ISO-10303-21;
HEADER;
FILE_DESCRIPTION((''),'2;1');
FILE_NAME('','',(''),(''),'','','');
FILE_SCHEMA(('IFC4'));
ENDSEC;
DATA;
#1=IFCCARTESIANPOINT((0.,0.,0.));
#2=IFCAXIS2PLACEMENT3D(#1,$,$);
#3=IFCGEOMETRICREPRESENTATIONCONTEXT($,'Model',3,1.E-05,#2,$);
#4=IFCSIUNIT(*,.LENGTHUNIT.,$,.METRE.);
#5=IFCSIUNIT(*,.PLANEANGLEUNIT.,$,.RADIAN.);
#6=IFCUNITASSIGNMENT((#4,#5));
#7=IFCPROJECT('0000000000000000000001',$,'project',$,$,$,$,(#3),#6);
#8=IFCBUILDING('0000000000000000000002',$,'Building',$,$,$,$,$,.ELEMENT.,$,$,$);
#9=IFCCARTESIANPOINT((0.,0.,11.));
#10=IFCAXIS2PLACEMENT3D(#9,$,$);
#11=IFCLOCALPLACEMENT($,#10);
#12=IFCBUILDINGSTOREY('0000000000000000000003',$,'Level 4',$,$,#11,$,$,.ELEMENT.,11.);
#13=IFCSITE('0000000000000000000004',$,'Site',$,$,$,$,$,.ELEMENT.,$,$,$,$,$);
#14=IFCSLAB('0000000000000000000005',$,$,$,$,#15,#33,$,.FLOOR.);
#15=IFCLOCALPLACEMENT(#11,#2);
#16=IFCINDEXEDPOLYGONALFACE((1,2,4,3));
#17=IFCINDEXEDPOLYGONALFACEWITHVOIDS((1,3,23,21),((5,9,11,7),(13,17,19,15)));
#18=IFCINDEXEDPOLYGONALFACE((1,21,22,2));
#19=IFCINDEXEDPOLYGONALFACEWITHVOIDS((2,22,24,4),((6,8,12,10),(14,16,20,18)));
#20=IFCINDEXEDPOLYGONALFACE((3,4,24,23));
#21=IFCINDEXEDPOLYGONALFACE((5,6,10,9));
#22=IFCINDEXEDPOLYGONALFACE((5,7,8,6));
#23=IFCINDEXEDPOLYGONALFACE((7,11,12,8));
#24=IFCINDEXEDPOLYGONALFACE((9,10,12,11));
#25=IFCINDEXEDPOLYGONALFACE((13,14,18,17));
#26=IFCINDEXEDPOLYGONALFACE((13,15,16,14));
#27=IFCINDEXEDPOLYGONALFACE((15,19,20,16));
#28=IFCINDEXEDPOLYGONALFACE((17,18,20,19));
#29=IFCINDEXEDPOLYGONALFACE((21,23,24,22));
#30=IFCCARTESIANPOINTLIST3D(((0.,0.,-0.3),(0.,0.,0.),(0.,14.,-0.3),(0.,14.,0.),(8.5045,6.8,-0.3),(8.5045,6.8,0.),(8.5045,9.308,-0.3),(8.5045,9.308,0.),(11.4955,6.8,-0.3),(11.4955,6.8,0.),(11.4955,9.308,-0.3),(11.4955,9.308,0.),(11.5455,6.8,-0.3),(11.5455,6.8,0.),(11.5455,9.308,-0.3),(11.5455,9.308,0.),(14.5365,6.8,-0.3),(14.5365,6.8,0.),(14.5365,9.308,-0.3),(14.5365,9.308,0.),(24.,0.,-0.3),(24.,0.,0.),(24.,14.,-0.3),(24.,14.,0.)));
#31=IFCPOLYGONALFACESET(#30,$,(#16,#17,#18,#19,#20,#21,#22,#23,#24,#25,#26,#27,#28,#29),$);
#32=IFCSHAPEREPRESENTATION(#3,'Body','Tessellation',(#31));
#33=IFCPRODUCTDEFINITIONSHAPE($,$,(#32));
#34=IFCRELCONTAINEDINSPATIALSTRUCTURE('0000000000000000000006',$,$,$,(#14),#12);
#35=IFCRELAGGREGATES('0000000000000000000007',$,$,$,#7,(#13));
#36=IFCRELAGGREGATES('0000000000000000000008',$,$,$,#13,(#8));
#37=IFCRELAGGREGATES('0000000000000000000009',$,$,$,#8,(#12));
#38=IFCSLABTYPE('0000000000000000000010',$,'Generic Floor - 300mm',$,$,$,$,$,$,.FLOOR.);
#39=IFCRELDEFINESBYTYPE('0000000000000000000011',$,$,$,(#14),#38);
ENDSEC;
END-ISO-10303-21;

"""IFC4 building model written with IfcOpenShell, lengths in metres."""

from ifc_helpers import new_model, si_unit, frame, origin, place, context, project, spatial, polyline, outline, extrude, type_object, element, save


model = new_model("IFC4")

# Units and contexts
model_context = context("Model", 3, precision=1e-05, world=origin())
ifc_project = project(units=[si_unit("LENGTHUNIT", "METRE"), si_unit("PLANEANGLEUNIT", "RADIAN")], contexts=[model_context])

# Site, building, storey
site = spatial("IfcSite", under=ifc_project, Name="Site", CompositionType="ELEMENT")
building = spatial("IfcBuilding", under=site, Name="Building", CompositionType="ELEMENT")
storey_placement = place(None, frame((0.0, 0.0, 11.0)))
storey = spatial("IfcBuildingStorey", under=building, at=storey_placement, Name="Level 4", CompositionType="ELEMENT", Elevation=11.0)

# Slab, openings
slab_type = type_object("IfcSlabType", Name="Generic Floor - 300mm", PredefinedType="FLOOR")
slab_placement = place(None, frame((0.0, 0.0, 11.0)))
slab = element("IfcSlab", 1, at=slab_placement, inside=storey, type_object=slab_type, PredefinedType="FLOOR", context=model_context, shape_type="SweptSolid", body=[
    extrude(outline(polyline([(0.0, 0.0), (24.0, 0.0), (24.0, 14.0), (0.0, 14.0), (0.0, 0.0)])), origin(), (0.0, 0.0, -1.0), 0.3),
])
opening_1_placement = place(None, frame((0.0, 0.0, 11.001)))
element("IfcOpeningElement", 2, at=opening_1_placement, cuts=slab, PredefinedType="OPENING", context=model_context, shape_type="SweptSolid", body=[
    extrude(outline(polyline([(8.5045, 6.8), (11.4955, 6.8), (11.4955, 9.308), (8.5045, 9.308), (8.5045, 6.8)])), origin(), (0.0, 0.0, -1.0), 0.302),
])
opening_2_placement = place(None, frame((0.0, 0.0, 11.001)))
element("IfcOpeningElement", 3, at=opening_2_placement, cuts=slab, PredefinedType="OPENING", context=model_context, shape_type="SweptSolid", body=[
    extrude(outline(polyline([(11.5455, 6.8), (14.5365, 6.8), (14.5365, 9.308), (11.5455, 9.308), (11.5455, 6.8)])), origin(), (0.0, 0.0, -1.0), 0.302),
])

save(model, "model.ifc")
